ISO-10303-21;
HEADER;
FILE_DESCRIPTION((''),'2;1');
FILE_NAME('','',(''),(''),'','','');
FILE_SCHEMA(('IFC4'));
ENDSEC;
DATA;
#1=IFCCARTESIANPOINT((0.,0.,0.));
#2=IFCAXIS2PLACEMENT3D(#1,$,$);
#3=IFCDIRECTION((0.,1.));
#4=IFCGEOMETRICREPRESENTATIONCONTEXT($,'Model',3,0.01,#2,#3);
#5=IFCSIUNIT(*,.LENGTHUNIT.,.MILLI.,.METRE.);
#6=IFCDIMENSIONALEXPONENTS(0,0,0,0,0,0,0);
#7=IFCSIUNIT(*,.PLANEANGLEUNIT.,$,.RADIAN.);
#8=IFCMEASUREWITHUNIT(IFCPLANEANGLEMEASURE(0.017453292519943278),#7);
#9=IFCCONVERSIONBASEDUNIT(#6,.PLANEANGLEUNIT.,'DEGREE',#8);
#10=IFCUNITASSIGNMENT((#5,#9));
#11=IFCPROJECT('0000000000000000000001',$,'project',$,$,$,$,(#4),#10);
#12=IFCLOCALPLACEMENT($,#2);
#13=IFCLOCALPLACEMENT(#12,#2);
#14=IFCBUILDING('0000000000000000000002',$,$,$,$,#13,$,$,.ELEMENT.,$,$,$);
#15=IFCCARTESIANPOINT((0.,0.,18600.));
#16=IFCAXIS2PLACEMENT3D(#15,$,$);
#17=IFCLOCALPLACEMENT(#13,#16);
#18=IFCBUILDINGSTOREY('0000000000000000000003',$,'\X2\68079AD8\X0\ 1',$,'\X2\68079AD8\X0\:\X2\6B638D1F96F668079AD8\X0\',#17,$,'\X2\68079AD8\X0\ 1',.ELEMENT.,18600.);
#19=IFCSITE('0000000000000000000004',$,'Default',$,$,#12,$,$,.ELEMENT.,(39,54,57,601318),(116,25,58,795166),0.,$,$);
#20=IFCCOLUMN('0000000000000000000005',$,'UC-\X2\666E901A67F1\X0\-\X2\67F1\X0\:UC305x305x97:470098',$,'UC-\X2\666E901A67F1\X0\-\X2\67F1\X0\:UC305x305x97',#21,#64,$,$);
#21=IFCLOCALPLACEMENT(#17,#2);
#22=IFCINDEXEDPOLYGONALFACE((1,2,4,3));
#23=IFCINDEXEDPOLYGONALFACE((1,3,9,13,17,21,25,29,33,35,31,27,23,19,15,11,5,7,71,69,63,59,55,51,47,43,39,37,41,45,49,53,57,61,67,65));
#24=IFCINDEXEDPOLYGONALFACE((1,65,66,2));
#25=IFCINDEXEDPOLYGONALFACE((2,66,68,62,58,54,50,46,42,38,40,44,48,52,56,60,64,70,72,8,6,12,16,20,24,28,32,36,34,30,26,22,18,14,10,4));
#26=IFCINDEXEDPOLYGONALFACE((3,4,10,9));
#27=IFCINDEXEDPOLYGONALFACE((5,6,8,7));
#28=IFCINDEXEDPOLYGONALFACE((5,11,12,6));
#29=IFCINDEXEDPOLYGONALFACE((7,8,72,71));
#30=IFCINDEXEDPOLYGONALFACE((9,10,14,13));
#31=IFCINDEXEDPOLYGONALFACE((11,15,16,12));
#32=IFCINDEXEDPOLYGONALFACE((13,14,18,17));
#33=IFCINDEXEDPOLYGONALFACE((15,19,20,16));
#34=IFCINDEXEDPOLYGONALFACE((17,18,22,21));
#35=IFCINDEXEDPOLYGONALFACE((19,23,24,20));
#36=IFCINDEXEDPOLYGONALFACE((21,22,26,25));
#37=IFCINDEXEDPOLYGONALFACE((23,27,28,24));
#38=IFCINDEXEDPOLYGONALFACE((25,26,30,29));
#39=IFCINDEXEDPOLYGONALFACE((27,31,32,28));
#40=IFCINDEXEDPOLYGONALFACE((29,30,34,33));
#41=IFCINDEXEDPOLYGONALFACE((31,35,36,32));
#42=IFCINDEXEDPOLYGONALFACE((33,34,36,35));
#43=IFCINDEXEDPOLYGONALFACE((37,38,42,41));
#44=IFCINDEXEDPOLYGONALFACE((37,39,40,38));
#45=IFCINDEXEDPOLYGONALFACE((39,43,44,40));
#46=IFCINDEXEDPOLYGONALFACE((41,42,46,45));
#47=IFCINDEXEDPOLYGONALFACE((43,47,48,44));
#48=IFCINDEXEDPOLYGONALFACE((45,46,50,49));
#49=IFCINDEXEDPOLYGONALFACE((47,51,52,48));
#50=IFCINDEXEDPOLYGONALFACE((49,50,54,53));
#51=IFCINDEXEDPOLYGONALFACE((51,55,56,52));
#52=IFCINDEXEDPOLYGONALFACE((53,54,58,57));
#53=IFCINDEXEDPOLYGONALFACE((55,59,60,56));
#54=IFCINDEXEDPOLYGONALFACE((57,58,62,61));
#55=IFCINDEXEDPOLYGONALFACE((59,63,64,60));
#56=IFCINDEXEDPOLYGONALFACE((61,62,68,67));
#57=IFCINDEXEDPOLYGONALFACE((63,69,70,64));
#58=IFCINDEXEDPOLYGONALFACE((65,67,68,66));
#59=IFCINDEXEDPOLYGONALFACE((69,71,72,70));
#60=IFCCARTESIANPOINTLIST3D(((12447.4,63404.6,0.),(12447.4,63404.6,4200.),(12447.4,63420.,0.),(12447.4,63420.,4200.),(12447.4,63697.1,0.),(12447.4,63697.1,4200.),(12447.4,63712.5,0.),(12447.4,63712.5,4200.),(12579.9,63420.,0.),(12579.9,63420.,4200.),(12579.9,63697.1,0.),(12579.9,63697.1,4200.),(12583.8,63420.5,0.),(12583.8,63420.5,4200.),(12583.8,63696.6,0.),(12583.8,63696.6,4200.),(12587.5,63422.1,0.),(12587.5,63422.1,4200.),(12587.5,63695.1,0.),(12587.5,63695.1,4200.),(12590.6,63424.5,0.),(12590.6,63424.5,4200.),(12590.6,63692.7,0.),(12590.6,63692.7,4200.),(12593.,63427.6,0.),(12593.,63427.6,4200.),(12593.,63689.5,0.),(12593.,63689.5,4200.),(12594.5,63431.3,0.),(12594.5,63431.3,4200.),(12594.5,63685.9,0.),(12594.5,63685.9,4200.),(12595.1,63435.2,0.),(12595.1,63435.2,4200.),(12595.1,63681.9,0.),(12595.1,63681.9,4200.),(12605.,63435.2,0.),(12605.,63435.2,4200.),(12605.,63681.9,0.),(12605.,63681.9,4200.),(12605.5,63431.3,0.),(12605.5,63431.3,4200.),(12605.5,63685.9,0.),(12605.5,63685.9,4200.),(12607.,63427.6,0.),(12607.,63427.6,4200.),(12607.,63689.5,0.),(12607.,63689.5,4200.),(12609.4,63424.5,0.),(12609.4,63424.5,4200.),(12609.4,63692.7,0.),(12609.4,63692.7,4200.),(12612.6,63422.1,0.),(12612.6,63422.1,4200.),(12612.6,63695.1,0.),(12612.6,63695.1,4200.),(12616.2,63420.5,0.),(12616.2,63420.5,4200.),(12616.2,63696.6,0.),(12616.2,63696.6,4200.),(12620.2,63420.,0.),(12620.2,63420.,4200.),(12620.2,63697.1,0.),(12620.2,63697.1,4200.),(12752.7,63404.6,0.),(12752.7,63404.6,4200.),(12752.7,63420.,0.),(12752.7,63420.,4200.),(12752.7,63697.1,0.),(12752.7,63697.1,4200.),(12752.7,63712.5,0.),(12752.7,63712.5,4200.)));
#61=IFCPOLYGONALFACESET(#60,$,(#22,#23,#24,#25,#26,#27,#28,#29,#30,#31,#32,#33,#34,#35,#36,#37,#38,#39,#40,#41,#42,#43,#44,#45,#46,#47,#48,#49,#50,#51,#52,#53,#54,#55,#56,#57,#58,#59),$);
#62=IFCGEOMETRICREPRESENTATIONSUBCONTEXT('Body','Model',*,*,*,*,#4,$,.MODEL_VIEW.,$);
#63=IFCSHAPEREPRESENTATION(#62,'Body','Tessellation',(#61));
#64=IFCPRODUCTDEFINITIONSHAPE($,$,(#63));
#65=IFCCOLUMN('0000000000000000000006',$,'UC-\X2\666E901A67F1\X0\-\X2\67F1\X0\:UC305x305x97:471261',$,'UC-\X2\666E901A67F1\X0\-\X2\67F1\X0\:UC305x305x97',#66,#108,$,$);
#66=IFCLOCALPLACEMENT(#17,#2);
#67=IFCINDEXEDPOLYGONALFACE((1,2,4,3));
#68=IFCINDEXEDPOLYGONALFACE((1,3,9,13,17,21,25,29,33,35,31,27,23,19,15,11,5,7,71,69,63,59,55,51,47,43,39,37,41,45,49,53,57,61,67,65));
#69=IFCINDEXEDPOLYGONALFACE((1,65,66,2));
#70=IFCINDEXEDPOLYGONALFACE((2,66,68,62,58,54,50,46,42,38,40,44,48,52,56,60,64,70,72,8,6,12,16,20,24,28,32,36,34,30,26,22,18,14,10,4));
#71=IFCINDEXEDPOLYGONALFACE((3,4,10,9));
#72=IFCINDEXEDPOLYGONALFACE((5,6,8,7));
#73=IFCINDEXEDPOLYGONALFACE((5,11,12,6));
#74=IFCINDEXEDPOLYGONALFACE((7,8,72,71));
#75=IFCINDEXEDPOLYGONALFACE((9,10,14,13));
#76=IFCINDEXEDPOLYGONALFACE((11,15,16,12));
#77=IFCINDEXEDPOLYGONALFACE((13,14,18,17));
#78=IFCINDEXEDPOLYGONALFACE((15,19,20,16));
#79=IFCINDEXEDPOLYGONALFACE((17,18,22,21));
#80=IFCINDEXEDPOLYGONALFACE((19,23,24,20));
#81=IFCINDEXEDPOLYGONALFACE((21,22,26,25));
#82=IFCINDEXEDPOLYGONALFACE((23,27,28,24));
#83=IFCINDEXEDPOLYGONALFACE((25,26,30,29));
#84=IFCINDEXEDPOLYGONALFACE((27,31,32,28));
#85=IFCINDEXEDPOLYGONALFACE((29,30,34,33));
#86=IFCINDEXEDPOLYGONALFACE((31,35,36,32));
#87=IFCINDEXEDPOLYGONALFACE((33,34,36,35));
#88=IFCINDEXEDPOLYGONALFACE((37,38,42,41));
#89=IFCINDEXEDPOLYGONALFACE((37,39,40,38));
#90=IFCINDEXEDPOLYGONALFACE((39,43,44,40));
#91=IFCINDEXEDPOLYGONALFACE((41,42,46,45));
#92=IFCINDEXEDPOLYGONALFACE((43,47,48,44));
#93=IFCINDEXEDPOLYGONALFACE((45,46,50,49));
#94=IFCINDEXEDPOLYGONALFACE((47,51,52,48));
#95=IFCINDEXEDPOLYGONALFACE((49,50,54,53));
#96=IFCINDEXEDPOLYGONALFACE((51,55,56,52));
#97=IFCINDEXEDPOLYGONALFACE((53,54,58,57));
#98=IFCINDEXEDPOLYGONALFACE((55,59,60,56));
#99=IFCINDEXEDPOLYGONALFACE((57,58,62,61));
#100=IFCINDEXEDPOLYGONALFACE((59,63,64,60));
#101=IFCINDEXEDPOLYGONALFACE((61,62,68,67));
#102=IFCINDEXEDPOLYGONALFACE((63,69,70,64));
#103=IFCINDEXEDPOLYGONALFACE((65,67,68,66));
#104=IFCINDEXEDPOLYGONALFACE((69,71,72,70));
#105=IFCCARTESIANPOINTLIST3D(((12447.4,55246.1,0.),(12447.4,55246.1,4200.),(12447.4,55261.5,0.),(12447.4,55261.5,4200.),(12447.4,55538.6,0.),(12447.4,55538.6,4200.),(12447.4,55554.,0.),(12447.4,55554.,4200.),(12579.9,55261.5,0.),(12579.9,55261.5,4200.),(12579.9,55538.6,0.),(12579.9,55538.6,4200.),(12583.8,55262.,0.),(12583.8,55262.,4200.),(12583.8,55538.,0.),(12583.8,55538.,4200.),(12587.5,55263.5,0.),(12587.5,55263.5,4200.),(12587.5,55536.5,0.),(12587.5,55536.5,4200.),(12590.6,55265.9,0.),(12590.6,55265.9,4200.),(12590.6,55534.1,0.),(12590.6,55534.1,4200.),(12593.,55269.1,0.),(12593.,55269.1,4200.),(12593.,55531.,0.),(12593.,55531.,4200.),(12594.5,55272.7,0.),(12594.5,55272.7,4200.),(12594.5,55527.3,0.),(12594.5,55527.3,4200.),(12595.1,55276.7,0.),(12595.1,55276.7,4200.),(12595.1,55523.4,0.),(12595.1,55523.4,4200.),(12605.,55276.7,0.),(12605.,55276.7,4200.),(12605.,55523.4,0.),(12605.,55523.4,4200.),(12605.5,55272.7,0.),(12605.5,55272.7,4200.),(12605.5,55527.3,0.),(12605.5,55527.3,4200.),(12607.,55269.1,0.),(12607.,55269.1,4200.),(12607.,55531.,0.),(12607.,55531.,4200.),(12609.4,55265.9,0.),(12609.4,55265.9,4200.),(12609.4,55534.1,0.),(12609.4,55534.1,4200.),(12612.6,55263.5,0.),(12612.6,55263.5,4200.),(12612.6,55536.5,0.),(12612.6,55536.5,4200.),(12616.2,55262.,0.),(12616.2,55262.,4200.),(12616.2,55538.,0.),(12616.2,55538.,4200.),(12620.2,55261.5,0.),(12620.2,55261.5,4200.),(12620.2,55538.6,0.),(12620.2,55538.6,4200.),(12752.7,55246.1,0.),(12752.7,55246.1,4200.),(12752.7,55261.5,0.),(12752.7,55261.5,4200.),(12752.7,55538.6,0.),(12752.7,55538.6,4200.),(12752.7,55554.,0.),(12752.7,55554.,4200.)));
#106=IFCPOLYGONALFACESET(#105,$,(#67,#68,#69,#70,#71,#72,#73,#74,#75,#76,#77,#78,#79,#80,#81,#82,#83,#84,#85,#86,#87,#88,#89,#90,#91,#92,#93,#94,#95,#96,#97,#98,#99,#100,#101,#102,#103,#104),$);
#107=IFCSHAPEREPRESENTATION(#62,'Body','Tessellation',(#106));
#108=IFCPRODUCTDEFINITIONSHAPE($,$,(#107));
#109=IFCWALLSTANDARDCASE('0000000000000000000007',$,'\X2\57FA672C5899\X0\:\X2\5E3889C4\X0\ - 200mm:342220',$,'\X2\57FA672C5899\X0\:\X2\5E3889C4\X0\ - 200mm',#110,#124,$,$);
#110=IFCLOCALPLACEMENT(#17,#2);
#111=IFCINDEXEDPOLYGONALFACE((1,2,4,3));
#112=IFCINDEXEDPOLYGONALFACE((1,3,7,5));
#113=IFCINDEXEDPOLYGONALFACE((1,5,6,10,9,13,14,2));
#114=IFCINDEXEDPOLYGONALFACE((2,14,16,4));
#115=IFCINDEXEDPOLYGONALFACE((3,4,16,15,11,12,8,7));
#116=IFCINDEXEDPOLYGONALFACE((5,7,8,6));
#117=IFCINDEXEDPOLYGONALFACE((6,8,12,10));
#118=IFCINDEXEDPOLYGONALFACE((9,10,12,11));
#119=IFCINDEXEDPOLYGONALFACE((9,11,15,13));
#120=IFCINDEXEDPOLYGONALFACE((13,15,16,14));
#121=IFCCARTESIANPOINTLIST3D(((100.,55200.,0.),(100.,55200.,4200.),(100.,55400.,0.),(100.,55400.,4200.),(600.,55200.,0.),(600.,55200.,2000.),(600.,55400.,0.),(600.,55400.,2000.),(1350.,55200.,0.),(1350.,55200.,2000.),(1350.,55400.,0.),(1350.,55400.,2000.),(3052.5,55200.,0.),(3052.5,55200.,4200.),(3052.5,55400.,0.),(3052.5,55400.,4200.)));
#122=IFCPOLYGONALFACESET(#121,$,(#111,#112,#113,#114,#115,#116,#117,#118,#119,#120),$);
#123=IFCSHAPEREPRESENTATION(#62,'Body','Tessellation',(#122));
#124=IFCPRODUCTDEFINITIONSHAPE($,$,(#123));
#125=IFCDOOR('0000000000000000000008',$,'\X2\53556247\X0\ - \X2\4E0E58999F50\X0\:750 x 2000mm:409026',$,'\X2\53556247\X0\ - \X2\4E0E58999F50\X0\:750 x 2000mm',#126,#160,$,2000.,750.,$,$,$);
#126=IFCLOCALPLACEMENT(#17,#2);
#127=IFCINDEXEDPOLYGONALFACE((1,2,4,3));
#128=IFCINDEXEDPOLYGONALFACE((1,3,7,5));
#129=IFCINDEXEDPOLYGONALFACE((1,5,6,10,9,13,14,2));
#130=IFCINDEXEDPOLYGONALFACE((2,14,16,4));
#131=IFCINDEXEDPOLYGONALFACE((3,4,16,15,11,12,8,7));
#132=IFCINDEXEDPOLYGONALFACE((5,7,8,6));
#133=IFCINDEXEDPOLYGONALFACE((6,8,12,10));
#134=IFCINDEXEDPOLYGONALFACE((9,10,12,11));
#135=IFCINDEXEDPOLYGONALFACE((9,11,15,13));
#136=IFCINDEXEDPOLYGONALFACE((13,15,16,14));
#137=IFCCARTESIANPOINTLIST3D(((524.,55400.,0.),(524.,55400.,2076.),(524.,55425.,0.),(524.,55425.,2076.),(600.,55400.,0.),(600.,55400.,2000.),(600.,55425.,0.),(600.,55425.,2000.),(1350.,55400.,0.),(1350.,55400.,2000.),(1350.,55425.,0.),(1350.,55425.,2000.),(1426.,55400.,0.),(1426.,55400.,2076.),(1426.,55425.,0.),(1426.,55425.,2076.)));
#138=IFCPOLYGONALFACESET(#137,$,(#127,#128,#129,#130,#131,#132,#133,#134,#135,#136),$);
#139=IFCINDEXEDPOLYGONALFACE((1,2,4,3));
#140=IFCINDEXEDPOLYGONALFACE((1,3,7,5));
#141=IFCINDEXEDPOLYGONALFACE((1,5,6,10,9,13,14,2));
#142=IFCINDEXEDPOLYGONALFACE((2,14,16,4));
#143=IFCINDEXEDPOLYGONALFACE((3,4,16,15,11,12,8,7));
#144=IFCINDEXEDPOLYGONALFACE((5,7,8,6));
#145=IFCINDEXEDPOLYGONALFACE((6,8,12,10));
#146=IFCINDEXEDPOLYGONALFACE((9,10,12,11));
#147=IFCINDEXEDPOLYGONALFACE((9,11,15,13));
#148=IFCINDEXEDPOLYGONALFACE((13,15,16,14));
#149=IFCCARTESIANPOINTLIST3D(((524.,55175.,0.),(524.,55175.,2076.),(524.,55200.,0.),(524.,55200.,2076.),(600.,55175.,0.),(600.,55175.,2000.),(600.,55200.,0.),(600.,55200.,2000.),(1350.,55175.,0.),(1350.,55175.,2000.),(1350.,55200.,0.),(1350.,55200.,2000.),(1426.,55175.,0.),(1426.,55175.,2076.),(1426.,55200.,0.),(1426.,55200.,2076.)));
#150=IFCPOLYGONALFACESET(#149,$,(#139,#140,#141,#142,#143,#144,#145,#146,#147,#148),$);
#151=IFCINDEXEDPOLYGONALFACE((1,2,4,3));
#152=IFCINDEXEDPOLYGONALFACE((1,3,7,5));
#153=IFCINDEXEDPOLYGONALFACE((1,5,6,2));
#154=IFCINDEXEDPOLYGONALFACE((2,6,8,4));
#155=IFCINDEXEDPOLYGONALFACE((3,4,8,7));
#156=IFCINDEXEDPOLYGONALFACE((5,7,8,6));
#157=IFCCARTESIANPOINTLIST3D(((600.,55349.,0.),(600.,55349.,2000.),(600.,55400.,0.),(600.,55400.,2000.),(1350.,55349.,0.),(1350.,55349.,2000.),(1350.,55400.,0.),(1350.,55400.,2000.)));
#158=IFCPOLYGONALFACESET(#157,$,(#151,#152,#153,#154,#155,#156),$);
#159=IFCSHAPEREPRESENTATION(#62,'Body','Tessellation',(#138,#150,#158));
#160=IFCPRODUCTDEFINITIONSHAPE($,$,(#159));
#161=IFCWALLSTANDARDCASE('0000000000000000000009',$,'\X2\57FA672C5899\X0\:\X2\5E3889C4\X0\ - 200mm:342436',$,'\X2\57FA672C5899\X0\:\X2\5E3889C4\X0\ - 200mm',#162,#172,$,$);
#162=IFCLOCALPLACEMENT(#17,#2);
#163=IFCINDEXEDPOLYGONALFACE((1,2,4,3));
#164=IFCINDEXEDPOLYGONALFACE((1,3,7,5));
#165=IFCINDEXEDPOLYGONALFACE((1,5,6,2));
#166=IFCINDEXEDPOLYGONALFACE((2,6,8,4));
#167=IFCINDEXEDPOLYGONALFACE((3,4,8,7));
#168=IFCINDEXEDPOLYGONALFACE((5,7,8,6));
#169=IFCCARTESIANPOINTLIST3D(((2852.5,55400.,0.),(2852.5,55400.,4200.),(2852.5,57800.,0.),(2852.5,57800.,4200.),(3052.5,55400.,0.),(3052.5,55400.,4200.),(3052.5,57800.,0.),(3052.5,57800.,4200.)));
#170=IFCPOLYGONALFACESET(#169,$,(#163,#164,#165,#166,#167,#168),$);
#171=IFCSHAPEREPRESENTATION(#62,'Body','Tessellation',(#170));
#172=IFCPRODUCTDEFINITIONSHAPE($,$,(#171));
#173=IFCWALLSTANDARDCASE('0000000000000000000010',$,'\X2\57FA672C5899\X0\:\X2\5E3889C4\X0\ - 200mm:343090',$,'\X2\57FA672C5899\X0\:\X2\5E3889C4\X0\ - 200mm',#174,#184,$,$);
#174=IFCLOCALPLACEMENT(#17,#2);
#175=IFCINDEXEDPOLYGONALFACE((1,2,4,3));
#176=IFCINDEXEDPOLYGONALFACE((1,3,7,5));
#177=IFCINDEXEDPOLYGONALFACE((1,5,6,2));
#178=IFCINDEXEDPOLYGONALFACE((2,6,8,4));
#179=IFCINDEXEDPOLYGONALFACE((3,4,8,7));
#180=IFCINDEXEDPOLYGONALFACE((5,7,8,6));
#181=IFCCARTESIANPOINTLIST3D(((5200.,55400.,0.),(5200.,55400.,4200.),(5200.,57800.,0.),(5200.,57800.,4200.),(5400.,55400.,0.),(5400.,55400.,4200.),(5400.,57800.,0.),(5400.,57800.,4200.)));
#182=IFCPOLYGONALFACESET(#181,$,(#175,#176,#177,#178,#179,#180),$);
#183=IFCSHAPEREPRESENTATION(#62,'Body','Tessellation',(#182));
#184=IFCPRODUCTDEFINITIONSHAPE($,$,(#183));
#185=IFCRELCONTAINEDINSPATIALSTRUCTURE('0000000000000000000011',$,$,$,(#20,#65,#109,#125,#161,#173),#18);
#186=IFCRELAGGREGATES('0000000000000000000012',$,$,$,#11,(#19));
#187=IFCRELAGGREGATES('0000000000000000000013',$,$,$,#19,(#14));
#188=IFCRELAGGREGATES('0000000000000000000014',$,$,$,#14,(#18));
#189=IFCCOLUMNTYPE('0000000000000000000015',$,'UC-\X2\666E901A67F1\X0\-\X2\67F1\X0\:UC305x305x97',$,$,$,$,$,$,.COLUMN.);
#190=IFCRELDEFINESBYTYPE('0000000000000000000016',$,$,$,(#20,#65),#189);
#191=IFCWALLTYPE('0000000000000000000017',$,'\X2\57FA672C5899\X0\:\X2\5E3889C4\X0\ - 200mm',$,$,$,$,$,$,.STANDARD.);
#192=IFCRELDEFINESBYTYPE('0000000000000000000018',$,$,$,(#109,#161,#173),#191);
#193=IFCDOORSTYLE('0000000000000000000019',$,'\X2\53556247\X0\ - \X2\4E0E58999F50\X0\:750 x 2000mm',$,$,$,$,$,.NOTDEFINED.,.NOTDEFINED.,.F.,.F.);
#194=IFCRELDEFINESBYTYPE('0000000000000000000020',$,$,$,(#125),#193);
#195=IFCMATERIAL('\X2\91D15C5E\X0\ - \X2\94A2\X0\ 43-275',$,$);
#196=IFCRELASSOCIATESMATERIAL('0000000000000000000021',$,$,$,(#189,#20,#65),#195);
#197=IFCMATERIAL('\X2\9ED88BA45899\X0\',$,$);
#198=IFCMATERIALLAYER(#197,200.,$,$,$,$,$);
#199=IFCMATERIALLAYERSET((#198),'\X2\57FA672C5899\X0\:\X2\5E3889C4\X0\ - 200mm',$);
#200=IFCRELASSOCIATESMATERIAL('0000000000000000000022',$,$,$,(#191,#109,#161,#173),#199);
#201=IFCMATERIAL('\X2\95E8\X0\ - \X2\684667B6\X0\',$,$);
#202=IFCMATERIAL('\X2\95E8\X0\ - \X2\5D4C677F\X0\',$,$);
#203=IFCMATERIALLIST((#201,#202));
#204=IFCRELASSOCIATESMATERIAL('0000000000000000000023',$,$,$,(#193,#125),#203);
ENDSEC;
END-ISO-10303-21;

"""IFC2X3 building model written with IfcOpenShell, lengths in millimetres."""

from ifc_helpers import new_model, entity, si_unit, converted_unit, direction, frame, frame_2d, origin, origin_2d_with_axis, place, context, subcontext, project, spatial, polyline, rectangle, i_section, outline, extrude, source, transform, mapped, material, material_list, layer, layer_set, layer_usage, type_object, type_shapes, element, fill, save


model = new_model("IFC2X3")

# Units and contexts
model_context = context("Model", 3, precision=0.01, world=origin(), true_north=direction((0.0, 1.0)))
body_context = subcontext(model_context, "Body", "Model", "MODEL_VIEW")
ifc_project = project(units=[si_unit("LENGTHUNIT", "METRE", prefix="MILLI"), converted_unit("PLANEANGLEUNIT", "DEGREE", entity("IfcPlaneAngleMeasure", 0.017453292519943278), si_unit("PLANEANGLEUNIT", "RADIAN"), dimensions=[0, 0, 0, 0, 0, 0, 0])], contexts=[model_context])

# Site, building, storey
site_placement = place(None, origin())
site = spatial("IfcSite", under=ifc_project, at=site_placement, Name="Default", CompositionType="ELEMENT", RefLatitude=(39, 54, 57, 601318), RefLongitude=(116, 25, 58, 795166), RefElevation=0.0)
building_placement = place(site_placement, origin())
building = spatial("IfcBuilding", under=site, at=building_placement, CompositionType="ELEMENT")
storey_placement = place(building_placement, frame((0.0, 0.0, 18600.0)))
storey = spatial("IfcBuildingStorey", under=building, at=storey_placement, Name="标高 1", ObjectType="标高:正负零标高", LongName="标高 1", CompositionType="ELEMENT", Elevation=18600.0)

# Columns
ifc_material_1 = material(Name="金属 - 钢 43-275")
column_type = type_object("IfcColumnType", Name="UC-普通柱-柱:UC305x305x97", PredefinedType="COLUMN", material=ifc_material_1)
shared_shape_1 = source(origin(), body_context, "Body", "SweptSolid", [
    extrude(i_section(OverallWidth=305.3, OverallDepth=307.9, WebThickness=9.9, FlangeThickness=15.4, FilletRadius=15.2, at=origin_2d_with_axis()), frame((0.0, 0.0, 18600.0), z_axis=(0.0, 0.0, 1.0), x_axis=(-1.0, 0.0, 0.0)), (0.0, 0.0, 1.0), 4200.0),
])
type_shapes(column_type, [shared_shape_1])
for number, where, name in (
    (1, (12600.0, 63558.6, -18600.0), "UC-普通柱-柱:UC305x305x97:470098"),
    (2, (12600.0, 55400.0, -18600.0), "UC-普通柱-柱:UC305x305x97:471261"),
):
    element("IfcColumn", number, at=place(storey_placement, frame(where)), inside=storey, type_object=column_type, material=ifc_material_1, Name=name, ObjectType="UC-普通柱-柱:UC305x305x97", context=body_context, shape_type="MappedRepresentation", body=[
        mapped(shared_shape_1, transform((0.0, 0.0, 0.0), scale=1.0)),
    ])

# Wall, opening, door
ifc_material_2 = material(Name="默认墙")
ifc_layer = layer(ifc_material_2, 200.0)
ifc_layer_set = layer_set([ifc_layer], Name="基本墙:常规 - 200mm")
ifc_layer_usage_1 = layer_usage(ifc_layer_set, "AXIS2", "NEGATIVE", 100.0)
wall_type = type_object("IfcWallType", Name="基本墙:常规 - 200mm", PredefinedType="STANDARD", material=ifc_layer_set)
wall_1_placement = place(storey_placement, frame((100.0, 55300.0, 0.0)))
wall_1 = element("IfcWallStandardCase", 3, at=wall_1_placement, inside=storey, type_object=wall_type, material=ifc_layer_usage_1, Name="基本墙:常规 - 200mm:342220", ObjectType="基本墙:常规 - 200mm", context=body_context, shape_type="SweptSolid", body=[
    extrude(rectangle(XDim=2952.5, YDim=200.0, at=frame_2d((1476.2, 0.0), x_axis=(-1.0, 0.0))), origin(), (0.0, 0.0, 1.0), 4200.0),
])
opening_placement = place(wall_1_placement, frame((500.0, -100.0, 0.0)))
opening = element("IfcOpeningElement", 4, at=opening_placement, cuts=wall_1, ObjectType="Opening", context=body_context, shape_type="SweptSolid", body=[
    extrude(rectangle(XDim=750.0, YDim=2000.0, at=frame_2d((1000.0, 375.0), x_axis=(0.0, -1.0))), frame((0.0, 0.0, 0.0), z_axis=(0.0, 1.0, 0.0), x_axis=(0.0, 0.0, 1.0)), (0.0, 0.0, 1.0), 200.0),
])
ifc_material_3 = material(Name="门 - 框架")
ifc_material_4 = material(Name="门 - 嵌板")
ifc_material_list = material_list([ifc_material_3, ifc_material_4])
door_style = type_object("IfcDoorStyle", Name="单扇 - 与墙齐:750 x 2000mm", ConstructionType="NOTDEFINED", OperationType="NOTDEFINED", ParameterTakesPrecedence=False, Sizeable=False, material=ifc_material_list)
shared_shape_2 = source(origin(), body_context, "Body", "SweptSolid", [
    extrude(outline(polyline([(-451.0, -1057.0), (451.0, -1057.0), (451.0, 1019.0), (375.0, 1019.0), (375.0, -981.0), (-375.0, -981.0), (-375.0, 1019.0), (-451.0, 1019.0), (-451.0, -1057.0)])), frame((375.0, 225.0, 1019.0), z_axis=(0.0, -1.0, 0.0), x_axis=(-1.0, 0.0, 0.0)), (0.0, 0.0, 1.0), 25.0),
    extrude(outline(polyline([(-1057.0, -451.0), (1019.0, -451.0), (1019.0, -375.0), (-981.0, -375.0), (-981.0, 375.0), (1019.0, 375.0), (1019.0, 451.0), (-1057.0, 451.0), (-1057.0, -451.0)])), frame((375.0, 0.0, 1019.0), z_axis=(0.0, -1.0, 0.0), x_axis=(0.0, 0.0, -1.0)), (0.0, 0.0, 1.0), 25.0),
    extrude(rectangle(XDim=750.0, YDim=51.0, at=frame_2d((0.0, 0.0), x_axis=(1.0, 0.0))), frame((375.0, 174.5, 0.0)), (0.0, 0.0, 1.0), 2000.0),
])
type_shapes(door_style, [shared_shape_2])
door_placement = place(opening_placement, origin())
door = element("IfcDoor", 5, at=door_placement, inside=storey, type_object=door_style, material=ifc_material_list, Name="单扇 - 与墙齐:750 x 2000mm:409026", ObjectType="单扇 - 与墙齐:750 x 2000mm", OverallHeight=2000.0, OverallWidth=750.0, context=body_context, shape_type="MappedRepresentation", body=[
    mapped(shared_shape_2, transform((0.0, 0.0, 0.0), scale=1.0)),
])
fill(opening, door)

# Walls
ifc_layer_usage_2 = layer_usage(ifc_layer_set, "AXIS2", "POSITIVE", -100.0)
wall_2_placement = place(storey_placement, frame((2952.5, 55400.0, 0.0), z_axis=(0.0, 0.0, 1.0), x_axis=(0.0, 1.0, 0.0)))
element("IfcWallStandardCase", 6, at=wall_2_placement, inside=storey, type_object=wall_type, material=ifc_layer_usage_2, Name="基本墙:常规 - 200mm:342436", ObjectType="基本墙:常规 - 200mm", context=body_context, shape_type="SweptSolid", body=[
    extrude(rectangle(XDim=2400.0, YDim=200.0, at=frame_2d((1200.0, 0.0), x_axis=(-1.0, 0.0))), origin(), (0.0, 0.0, 1.0), 4200.0),
])
ifc_layer_usage_3 = layer_usage(ifc_layer_set, "AXIS2", "NEGATIVE", 100.0)
wall_3_placement = place(storey_placement, frame((5300.0, 55400.0, 0.0), z_axis=(0.0, 0.0, 1.0), x_axis=(0.0, 1.0, 0.0)))
element("IfcWallStandardCase", 7, at=wall_3_placement, inside=storey, type_object=wall_type, material=ifc_layer_usage_3, Name="基本墙:常规 - 200mm:343090", ObjectType="基本墙:常规 - 200mm", context=body_context, shape_type="SweptSolid", body=[
    extrude(rectangle(XDim=2400.0, YDim=200.0, at=frame_2d((1200.0, 0.0), x_axis=(-1.0, 0.0))), origin(), (0.0, 0.0, 1.0), 4200.0),
])

save(model, "model.ifc")
